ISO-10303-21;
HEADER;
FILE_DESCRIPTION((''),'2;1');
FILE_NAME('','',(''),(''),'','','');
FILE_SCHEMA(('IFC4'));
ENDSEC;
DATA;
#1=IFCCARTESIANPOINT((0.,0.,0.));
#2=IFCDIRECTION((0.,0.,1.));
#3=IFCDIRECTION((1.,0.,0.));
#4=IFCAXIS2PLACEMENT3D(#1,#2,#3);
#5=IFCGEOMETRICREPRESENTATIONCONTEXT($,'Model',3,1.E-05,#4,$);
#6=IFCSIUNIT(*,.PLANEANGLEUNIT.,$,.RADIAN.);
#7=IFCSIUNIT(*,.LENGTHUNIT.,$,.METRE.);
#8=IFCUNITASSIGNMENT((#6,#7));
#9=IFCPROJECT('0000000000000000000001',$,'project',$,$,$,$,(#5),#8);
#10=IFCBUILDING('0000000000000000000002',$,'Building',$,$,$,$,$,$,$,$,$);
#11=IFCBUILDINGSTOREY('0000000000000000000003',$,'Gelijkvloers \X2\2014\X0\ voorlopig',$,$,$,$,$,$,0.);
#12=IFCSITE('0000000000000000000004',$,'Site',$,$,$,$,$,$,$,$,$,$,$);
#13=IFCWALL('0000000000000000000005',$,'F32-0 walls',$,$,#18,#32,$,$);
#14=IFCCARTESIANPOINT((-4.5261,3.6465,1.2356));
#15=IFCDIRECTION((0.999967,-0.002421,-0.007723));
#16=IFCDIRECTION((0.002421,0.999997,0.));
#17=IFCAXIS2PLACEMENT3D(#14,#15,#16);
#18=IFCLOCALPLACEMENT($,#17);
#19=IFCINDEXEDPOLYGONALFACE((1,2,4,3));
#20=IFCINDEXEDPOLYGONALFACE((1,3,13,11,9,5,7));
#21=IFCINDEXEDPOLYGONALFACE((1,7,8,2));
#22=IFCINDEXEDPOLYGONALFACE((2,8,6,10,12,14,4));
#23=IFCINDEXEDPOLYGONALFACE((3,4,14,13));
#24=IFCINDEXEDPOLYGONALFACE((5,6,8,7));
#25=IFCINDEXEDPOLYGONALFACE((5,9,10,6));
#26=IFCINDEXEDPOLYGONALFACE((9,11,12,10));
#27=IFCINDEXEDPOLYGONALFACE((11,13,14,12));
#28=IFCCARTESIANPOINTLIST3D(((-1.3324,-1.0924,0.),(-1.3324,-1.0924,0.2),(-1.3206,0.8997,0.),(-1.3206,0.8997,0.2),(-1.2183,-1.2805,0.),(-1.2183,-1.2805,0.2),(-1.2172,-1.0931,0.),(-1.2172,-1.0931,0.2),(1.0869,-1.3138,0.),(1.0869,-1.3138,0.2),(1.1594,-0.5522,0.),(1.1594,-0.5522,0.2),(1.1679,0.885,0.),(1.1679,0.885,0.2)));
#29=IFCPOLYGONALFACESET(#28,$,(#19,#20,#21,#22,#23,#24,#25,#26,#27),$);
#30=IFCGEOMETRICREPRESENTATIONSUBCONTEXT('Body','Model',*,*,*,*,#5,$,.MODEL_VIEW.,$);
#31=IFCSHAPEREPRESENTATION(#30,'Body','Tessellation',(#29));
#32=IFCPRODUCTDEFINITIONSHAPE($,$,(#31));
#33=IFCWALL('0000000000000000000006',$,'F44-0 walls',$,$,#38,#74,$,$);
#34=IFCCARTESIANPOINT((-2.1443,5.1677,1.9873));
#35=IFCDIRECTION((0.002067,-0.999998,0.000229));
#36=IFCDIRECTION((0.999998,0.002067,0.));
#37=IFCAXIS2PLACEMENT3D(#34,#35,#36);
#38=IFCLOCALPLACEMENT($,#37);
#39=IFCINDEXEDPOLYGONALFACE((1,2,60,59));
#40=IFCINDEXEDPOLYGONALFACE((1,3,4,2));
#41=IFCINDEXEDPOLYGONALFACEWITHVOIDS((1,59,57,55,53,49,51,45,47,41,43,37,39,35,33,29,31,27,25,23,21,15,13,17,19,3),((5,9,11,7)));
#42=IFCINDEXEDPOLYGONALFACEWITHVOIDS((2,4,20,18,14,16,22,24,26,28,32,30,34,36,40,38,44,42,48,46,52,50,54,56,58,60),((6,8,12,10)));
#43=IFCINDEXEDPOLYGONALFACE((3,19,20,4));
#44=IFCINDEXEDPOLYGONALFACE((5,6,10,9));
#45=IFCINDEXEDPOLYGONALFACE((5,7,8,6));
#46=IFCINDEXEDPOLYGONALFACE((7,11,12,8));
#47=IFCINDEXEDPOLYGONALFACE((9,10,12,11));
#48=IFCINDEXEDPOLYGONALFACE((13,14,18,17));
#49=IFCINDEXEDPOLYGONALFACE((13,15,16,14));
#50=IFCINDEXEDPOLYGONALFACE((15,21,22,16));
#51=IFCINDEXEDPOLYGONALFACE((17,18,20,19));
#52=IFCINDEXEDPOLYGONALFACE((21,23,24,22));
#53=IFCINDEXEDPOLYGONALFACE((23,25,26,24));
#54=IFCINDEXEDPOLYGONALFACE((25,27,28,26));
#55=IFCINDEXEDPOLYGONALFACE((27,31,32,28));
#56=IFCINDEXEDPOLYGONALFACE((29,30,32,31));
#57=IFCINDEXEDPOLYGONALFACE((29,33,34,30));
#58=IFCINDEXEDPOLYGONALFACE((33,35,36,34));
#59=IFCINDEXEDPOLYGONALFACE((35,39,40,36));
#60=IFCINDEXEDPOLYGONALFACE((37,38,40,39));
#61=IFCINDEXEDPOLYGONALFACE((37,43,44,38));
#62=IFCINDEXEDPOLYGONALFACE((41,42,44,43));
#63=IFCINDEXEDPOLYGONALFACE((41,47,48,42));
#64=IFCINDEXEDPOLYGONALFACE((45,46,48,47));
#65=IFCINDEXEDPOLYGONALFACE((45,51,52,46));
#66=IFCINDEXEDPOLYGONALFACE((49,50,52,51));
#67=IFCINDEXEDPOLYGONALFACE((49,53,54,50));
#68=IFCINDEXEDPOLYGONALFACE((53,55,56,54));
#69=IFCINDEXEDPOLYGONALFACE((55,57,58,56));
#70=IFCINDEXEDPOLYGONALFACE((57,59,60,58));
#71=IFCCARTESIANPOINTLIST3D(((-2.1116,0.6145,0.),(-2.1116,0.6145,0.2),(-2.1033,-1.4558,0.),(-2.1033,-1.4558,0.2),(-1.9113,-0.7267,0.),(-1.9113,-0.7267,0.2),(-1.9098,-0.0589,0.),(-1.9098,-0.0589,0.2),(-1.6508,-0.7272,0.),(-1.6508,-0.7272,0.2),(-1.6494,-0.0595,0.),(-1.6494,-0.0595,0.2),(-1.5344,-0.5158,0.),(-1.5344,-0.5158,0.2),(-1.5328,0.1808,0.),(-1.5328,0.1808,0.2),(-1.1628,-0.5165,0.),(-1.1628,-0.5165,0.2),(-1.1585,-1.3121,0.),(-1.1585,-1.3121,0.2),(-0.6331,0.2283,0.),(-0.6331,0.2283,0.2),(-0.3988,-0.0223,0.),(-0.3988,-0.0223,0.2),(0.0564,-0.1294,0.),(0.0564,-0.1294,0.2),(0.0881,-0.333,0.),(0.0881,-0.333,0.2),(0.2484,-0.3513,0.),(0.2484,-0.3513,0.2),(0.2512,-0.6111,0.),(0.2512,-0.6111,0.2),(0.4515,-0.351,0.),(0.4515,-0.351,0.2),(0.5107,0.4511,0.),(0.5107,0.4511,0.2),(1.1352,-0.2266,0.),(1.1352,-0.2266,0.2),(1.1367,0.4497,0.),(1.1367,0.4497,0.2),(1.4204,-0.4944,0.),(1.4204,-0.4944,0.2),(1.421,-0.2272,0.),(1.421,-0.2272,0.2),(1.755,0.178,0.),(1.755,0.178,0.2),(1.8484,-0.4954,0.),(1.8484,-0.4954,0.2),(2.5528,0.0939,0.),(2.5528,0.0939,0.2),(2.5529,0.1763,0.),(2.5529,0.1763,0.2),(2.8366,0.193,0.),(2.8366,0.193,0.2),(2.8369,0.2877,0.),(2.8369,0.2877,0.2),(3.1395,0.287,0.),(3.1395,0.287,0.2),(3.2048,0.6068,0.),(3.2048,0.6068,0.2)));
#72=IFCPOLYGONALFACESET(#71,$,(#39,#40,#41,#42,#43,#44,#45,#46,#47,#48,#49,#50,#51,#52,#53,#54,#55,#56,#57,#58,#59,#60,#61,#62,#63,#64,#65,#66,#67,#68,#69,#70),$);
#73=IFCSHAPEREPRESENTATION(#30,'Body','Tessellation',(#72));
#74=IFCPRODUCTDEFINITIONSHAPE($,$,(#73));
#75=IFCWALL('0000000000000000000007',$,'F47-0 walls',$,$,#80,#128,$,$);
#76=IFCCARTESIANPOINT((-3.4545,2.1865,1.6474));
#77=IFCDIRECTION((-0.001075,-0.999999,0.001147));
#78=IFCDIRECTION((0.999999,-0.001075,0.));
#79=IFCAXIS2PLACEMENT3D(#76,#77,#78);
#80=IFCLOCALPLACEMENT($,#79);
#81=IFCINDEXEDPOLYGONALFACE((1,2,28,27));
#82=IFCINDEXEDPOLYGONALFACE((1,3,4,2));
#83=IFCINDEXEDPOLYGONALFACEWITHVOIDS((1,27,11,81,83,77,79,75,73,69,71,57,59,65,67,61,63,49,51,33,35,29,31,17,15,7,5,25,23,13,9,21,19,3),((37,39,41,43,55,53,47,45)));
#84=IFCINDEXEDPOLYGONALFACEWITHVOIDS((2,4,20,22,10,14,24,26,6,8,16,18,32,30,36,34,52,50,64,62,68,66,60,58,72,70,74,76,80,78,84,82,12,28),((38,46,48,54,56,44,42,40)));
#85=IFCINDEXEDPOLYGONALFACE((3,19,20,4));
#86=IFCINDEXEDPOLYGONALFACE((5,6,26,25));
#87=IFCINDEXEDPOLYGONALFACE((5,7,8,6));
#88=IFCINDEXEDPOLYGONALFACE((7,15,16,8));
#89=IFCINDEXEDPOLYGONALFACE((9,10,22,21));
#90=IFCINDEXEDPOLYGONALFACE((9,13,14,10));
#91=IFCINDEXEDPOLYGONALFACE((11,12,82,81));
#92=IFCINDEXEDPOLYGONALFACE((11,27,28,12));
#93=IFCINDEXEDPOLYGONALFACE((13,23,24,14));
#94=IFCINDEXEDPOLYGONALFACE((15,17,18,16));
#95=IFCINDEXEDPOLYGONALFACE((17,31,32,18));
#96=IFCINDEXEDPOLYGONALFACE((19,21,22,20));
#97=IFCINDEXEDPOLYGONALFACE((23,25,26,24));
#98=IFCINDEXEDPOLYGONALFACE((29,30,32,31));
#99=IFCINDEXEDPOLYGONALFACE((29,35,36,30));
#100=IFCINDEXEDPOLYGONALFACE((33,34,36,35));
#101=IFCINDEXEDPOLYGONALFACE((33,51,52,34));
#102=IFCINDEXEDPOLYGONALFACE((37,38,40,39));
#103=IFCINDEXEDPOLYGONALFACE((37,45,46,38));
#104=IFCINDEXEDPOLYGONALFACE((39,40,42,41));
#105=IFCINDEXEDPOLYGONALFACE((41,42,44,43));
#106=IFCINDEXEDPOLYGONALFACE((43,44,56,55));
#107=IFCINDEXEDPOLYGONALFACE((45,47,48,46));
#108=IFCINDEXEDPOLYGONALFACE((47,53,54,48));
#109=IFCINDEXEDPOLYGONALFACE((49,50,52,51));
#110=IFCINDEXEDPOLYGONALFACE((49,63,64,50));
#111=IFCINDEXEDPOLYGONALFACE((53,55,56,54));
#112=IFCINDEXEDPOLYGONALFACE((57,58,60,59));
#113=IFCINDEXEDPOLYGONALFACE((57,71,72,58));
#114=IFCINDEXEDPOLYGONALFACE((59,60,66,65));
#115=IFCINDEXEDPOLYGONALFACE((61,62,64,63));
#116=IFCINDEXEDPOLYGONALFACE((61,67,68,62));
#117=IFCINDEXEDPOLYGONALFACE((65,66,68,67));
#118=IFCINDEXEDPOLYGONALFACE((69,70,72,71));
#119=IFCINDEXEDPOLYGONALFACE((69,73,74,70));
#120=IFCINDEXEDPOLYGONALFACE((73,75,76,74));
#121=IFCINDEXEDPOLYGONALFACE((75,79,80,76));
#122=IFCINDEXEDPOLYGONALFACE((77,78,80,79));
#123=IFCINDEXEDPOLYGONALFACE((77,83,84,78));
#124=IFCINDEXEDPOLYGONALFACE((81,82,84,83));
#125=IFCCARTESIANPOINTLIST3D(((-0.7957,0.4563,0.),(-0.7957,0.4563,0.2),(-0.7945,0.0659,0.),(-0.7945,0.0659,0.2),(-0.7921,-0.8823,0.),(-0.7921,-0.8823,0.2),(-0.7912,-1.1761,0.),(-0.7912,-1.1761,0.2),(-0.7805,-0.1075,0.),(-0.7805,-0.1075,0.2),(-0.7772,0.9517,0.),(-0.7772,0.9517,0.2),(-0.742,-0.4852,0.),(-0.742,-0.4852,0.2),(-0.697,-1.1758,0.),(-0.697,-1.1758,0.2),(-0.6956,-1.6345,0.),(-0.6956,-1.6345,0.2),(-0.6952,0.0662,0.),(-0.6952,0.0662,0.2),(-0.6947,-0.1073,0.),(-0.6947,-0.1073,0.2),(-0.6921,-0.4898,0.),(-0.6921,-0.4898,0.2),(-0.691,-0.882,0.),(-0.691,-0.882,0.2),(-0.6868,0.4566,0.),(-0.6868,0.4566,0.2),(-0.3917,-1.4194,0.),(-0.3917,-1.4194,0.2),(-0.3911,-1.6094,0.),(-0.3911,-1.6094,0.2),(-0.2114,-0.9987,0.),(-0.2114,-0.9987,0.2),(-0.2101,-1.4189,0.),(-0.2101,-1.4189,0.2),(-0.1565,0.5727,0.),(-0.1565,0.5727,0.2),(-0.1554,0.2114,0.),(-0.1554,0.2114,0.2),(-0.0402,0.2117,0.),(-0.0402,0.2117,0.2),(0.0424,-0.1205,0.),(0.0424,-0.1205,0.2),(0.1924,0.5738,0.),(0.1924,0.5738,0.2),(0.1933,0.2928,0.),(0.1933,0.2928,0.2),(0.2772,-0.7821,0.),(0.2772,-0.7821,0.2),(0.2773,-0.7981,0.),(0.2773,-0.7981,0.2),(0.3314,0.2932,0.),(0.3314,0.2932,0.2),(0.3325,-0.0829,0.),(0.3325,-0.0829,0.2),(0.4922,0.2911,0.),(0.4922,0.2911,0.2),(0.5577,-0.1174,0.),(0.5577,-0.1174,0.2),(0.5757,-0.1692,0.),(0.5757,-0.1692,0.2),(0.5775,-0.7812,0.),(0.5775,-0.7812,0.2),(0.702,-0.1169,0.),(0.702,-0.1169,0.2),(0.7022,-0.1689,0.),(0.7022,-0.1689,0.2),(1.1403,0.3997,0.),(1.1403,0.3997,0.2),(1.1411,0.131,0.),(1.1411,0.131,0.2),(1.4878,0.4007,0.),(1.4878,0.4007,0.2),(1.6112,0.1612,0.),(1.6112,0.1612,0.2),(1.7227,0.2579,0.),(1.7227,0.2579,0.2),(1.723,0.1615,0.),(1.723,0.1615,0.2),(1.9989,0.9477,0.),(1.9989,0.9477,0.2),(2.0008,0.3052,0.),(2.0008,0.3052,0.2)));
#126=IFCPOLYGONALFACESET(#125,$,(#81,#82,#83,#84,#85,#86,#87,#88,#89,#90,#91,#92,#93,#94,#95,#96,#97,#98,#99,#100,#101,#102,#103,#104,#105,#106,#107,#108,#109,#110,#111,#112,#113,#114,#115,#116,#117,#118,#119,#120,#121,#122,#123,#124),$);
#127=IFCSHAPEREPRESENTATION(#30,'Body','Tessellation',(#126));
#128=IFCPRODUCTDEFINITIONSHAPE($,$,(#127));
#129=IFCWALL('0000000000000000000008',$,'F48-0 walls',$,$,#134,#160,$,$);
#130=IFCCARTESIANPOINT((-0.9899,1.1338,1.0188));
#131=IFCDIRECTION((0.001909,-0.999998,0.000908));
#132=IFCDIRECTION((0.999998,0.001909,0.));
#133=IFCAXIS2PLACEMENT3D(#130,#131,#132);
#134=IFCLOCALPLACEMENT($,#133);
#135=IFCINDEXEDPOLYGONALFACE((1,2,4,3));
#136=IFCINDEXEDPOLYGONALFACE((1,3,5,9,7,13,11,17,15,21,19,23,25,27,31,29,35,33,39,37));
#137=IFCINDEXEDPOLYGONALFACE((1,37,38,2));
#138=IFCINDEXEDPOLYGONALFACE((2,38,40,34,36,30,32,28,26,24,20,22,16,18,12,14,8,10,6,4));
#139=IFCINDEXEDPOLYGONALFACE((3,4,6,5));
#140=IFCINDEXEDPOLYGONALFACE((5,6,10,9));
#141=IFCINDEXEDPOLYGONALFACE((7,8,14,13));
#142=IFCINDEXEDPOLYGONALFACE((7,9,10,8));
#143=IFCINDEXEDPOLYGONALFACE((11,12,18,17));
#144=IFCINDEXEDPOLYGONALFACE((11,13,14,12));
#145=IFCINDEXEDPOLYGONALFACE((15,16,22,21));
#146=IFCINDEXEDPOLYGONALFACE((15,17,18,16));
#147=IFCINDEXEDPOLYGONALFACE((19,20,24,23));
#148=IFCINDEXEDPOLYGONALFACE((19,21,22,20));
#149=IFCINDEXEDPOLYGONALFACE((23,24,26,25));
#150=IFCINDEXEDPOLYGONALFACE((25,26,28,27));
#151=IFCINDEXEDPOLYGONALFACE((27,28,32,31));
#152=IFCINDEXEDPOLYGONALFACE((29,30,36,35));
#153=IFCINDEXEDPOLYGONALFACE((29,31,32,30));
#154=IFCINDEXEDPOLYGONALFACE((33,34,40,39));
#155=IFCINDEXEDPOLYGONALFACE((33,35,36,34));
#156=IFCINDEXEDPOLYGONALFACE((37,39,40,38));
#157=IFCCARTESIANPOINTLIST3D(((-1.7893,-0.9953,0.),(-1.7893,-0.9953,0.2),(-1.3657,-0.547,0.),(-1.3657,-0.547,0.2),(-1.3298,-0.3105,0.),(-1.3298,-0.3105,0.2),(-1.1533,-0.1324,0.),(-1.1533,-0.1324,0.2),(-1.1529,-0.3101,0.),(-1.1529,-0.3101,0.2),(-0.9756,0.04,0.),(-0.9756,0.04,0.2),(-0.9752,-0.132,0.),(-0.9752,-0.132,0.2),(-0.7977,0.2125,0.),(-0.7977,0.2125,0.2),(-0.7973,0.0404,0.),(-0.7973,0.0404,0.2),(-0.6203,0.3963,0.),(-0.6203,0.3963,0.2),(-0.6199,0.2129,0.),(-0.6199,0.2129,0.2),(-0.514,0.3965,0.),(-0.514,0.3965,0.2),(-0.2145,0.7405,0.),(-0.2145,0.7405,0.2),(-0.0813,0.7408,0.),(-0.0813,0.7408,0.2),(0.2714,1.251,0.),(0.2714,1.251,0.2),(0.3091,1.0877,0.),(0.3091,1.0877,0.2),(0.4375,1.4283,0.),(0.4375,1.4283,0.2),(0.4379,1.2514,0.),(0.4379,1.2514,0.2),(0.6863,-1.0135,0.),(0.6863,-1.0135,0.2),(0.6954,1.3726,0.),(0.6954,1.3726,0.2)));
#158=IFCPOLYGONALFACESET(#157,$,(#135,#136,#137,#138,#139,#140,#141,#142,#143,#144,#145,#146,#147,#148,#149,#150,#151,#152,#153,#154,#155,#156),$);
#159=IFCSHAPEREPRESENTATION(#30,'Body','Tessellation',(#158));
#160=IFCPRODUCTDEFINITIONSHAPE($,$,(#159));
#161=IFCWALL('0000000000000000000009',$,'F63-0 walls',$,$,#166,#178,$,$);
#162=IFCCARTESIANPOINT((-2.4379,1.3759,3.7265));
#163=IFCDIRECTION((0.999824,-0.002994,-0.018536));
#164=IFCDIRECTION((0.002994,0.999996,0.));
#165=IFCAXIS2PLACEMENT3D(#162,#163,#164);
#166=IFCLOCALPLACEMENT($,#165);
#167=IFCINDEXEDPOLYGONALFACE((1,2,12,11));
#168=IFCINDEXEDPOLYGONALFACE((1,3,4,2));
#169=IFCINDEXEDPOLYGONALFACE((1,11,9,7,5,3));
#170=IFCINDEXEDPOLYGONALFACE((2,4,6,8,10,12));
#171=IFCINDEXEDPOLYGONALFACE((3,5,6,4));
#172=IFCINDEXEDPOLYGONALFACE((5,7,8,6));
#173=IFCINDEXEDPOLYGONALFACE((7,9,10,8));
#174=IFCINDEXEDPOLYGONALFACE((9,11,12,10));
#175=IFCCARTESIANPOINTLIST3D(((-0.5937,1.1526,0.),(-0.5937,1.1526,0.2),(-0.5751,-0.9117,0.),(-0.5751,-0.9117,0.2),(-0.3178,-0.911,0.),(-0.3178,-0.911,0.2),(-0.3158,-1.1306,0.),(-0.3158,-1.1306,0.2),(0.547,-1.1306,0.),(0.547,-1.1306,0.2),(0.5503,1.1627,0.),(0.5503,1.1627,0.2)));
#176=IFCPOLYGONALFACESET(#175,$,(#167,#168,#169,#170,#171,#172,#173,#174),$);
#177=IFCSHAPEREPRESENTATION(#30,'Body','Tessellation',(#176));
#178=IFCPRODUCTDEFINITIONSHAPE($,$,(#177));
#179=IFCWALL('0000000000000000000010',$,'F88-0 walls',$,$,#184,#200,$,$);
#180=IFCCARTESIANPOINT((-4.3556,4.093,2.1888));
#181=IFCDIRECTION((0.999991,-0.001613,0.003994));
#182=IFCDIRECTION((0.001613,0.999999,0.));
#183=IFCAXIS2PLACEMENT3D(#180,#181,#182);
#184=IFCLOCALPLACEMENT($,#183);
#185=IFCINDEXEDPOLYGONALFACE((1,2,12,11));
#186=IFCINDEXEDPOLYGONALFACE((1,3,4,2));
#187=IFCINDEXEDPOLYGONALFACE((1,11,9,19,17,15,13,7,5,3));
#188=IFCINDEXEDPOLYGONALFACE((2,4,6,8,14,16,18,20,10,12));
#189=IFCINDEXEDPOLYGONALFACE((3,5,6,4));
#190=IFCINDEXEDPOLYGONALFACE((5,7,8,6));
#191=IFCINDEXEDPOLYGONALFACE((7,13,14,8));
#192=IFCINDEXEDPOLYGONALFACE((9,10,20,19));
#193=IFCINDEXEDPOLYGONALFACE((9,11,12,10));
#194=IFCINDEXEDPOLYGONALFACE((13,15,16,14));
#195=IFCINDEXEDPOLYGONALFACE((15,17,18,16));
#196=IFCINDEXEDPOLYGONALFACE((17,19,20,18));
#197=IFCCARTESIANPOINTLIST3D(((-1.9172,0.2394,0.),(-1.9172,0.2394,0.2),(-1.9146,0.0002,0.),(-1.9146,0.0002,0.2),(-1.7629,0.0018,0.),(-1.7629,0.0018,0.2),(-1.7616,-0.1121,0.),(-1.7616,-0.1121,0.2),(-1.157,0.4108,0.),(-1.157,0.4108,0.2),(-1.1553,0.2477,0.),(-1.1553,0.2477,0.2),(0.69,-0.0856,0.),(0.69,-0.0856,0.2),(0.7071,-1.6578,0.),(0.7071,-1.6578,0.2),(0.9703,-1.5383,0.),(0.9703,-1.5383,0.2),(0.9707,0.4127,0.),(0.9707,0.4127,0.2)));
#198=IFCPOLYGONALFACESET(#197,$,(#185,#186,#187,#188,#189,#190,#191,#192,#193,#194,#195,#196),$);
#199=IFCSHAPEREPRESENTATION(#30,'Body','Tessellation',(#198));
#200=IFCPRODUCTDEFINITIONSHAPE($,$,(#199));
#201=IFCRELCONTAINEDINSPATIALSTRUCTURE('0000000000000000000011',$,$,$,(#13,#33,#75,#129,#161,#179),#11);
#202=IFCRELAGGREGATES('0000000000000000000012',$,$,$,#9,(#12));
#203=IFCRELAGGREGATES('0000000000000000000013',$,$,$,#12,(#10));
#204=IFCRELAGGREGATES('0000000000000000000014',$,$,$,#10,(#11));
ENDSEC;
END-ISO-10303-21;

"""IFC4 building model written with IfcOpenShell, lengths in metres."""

from ifc_helpers import new_model, si_unit, frame, origin_with_axes, place, context, subcontext, project, spatial, polyline, outline, extrude, element, save


model = new_model("IFC4")

# Units and contexts
model_context = context("Model", 3, precision=1e-05, world=origin_with_axes())
body_context = subcontext(model_context, "Body", "Model", "MODEL_VIEW")
ifc_project = project(units=[si_unit("PLANEANGLEUNIT", "RADIAN"), si_unit("LENGTHUNIT", "METRE")], contexts=[model_context])

# Site, building, storey
site = spatial("IfcSite", under=ifc_project, Name="Site")
building = spatial("IfcBuilding", under=site, Name="Building")
storey = spatial("IfcBuildingStorey", under=building, Name="Gelijkvloers — voorlopig", Elevation=0.0)

# Wall
wall_1_placement = place(None, frame((-4.5261, 3.6465, 1.2356), z_axis=(0.999967, -0.002421, -0.007723), x_axis=(0.002421, 0.999997, 0.0)))
element("IfcWall", 1, at=wall_1_placement, inside=storey, Name="F32-0 walls", context=body_context, shape_type="SweptSolid", body=[
    extrude(outline(polyline([(-1.2183, -1.2805), (1.0869, -1.3138), (1.1594, -0.5522), (1.1679, 0.885), (-1.3206, 0.8997), (-1.3324, -1.0924), (-1.2172, -1.0931), (-1.2183, -1.2805)])), origin_with_axes(), (0.0, 0.0, 1.0), 0.2),
])

# Walls, openings
wall_2_placement = place(None, frame((-2.1443, 5.1677, 1.9873), z_axis=(0.002067, -0.999998, 0.000229), x_axis=(0.999998, 0.002067, 0.0)))
wall_2 = element("IfcWall", 2, at=wall_2_placement, inside=storey, Name="F44-0 walls", context=body_context, shape_type="SweptSolid", body=[
    extrude(outline(polyline([(-2.1033, -1.4558), (-1.1585, -1.3121), (-1.1628, -0.5165), (-1.5344, -0.5158), (-1.5328, 0.1808), (-0.6331, 0.2283), (-0.3988, -0.0223), (0.0564, -0.1294), (0.0881, -0.333), (0.2512, -0.6111), (0.2484, -0.3513), (0.4515, -0.351), (0.5107, 0.4511), (1.1367, 0.4497), (1.1352, -0.2266), (1.421, -0.2272), (1.4204, -0.4944), (1.8484, -0.4954), (1.755, 0.178), (2.5529, 0.1763), (2.5528, 0.0939), (2.8366, 0.193), (2.8369, 0.2877), (3.1395, 0.287), (3.2048, 0.6068), (-2.1116, 0.6145), (-2.1033, -1.4558)])), origin_with_axes(), (0.0, 0.0, 1.0), 0.2),
])
opening_1_placement = place(wall_2_placement, frame((0.0, 0.0, -0.05), z_axis=(0.0, 0.0, 1.0), x_axis=(1.0, 0.0, 0.0)))
element("IfcOpeningElement", 3, at=opening_1_placement, cuts=wall_2, PredefinedType="OPENING", context=body_context, shape_type="SweptSolid", body=[
    extrude(outline(polyline([(-1.9113, -0.7267), (-1.9098, -0.0589), (-1.6494, -0.0595), (-1.6508, -0.7272), (-1.9113, -0.7267)])), origin_with_axes(), (0.0, 0.0, 1.0), 0.3),
])
wall_3_placement = place(None, frame((-3.4545, 2.1865, 1.6474), z_axis=(-0.001075, -0.999999, 0.001147), x_axis=(0.999999, -0.001075, 0.0)))
wall_3 = element("IfcWall", 4, at=wall_3_placement, inside=storey, Name="F47-0 walls", context=body_context, shape_type="SweptSolid", body=[
    extrude(outline(polyline([(-0.6956, -1.6345), (-0.3911, -1.6094), (-0.3917, -1.4194), (-0.2101, -1.4189), (-0.2114, -0.9987), (0.2773, -0.7981), (0.2772, -0.7821), (0.5775, -0.7812), (0.5757, -0.1692), (0.7022, -0.1689), (0.702, -0.1169), (0.5577, -0.1174), (0.4922, 0.2911), (1.1411, 0.131), (1.1403, 0.3997), (1.4878, 0.4007), (1.6112, 0.1612), (1.723, 0.1615), (1.7227, 0.2579), (2.0008, 0.3052), (1.9989, 0.9477), (-0.7772, 0.9517), (-0.6868, 0.4566), (-0.7957, 0.4563), (-0.7945, 0.0659), (-0.6952, 0.0662), (-0.6947, -0.1073), (-0.7805, -0.1075), (-0.742, -0.4852), (-0.6921, -0.4898), (-0.691, -0.882), (-0.7921, -0.8823), (-0.7912, -1.1761), (-0.697, -1.1758), (-0.6956, -1.6345)])), origin_with_axes(), (0.0, 0.0, 1.0), 0.2),
])
opening_2_placement = place(wall_3_placement, frame((0.0, 0.0, -0.05), z_axis=(0.0, 0.0, 1.0), x_axis=(1.0, 0.0, 0.0)))
element("IfcOpeningElement", 5, at=opening_2_placement, cuts=wall_3, PredefinedType="OPENING", context=body_context, shape_type="SweptSolid", body=[
    extrude(outline(polyline([(0.0424, -0.1205), (-0.0402, 0.2117), (-0.1554, 0.2114), (-0.1565, 0.5727), (0.1924, 0.5738), (0.1933, 0.2928), (0.3314, 0.2932), (0.3325, -0.0829), (0.0424, -0.1205)])), origin_with_axes(), (0.0, 0.0, 1.0), 0.3),
])

# Walls
wall_4_placement = place(None, frame((-0.9899, 1.1338, 1.0188), z_axis=(0.001909, -0.999998, 0.000908), x_axis=(0.999998, 0.001909, 0.0)))
element("IfcWall", 6, at=wall_4_placement, inside=storey, Name="F48-0 walls", context=body_context, shape_type="SweptSolid", body=[
    extrude(outline(polyline([(-1.7893, -0.9953), (0.6863, -1.0135), (0.6954, 1.3726), (0.4375, 1.4283), (0.4379, 1.2514), (0.2714, 1.251), (0.3091, 1.0877), (-0.0813, 0.7408), (-0.2145, 0.7405), (-0.514, 0.3965), (-0.6203, 0.3963), (-0.6199, 0.2129), (-0.7977, 0.2125), (-0.7973, 0.0404), (-0.9756, 0.04), (-0.9752, -0.132), (-1.1533, -0.1324), (-1.1529, -0.3101), (-1.3298, -0.3105), (-1.3657, -0.547), (-1.7893, -0.9953)])), origin_with_axes(), (0.0, 0.0, 1.0), 0.2),
])
wall_5_placement = place(None, frame((-2.4379, 1.3759, 3.7265), z_axis=(0.999824, -0.002994, -0.018536), x_axis=(0.002994, 0.999996, 0.0)))
element("IfcWall", 7, at=wall_5_placement, inside=storey, Name="F63-0 walls", context=body_context, shape_type="SweptSolid", body=[
    extrude(outline(polyline([(-0.3158, -1.1306), (0.547, -1.1306), (0.5503, 1.1627), (-0.5937, 1.1526), (-0.5751, -0.9117), (-0.3178, -0.911), (-0.3158, -1.1306)])), origin_with_axes(), (0.0, 0.0, 1.0), 0.2),
])
wall_6_placement = place(None, frame((-4.3556, 4.093, 2.1888), z_axis=(0.999991, -0.001613, 0.003994), x_axis=(0.001613, 0.999999, 0.0)))
element("IfcWall", 8, at=wall_6_placement, inside=storey, Name="F88-0 walls", context=body_context, shape_type="SweptSolid", body=[
    extrude(outline(polyline([(0.7071, -1.6578), (0.9703, -1.5383), (0.9707, 0.4127), (-1.157, 0.4108), (-1.1553, 0.2477), (-1.9172, 0.2394), (-1.9146, 0.0002), (-1.7629, 0.0018), (-1.7616, -0.1121), (0.69, -0.0856), (0.7071, -1.6578)])), origin_with_axes(), (0.0, 0.0, 1.0), 0.2),
])

save(model, "model.ifc")
